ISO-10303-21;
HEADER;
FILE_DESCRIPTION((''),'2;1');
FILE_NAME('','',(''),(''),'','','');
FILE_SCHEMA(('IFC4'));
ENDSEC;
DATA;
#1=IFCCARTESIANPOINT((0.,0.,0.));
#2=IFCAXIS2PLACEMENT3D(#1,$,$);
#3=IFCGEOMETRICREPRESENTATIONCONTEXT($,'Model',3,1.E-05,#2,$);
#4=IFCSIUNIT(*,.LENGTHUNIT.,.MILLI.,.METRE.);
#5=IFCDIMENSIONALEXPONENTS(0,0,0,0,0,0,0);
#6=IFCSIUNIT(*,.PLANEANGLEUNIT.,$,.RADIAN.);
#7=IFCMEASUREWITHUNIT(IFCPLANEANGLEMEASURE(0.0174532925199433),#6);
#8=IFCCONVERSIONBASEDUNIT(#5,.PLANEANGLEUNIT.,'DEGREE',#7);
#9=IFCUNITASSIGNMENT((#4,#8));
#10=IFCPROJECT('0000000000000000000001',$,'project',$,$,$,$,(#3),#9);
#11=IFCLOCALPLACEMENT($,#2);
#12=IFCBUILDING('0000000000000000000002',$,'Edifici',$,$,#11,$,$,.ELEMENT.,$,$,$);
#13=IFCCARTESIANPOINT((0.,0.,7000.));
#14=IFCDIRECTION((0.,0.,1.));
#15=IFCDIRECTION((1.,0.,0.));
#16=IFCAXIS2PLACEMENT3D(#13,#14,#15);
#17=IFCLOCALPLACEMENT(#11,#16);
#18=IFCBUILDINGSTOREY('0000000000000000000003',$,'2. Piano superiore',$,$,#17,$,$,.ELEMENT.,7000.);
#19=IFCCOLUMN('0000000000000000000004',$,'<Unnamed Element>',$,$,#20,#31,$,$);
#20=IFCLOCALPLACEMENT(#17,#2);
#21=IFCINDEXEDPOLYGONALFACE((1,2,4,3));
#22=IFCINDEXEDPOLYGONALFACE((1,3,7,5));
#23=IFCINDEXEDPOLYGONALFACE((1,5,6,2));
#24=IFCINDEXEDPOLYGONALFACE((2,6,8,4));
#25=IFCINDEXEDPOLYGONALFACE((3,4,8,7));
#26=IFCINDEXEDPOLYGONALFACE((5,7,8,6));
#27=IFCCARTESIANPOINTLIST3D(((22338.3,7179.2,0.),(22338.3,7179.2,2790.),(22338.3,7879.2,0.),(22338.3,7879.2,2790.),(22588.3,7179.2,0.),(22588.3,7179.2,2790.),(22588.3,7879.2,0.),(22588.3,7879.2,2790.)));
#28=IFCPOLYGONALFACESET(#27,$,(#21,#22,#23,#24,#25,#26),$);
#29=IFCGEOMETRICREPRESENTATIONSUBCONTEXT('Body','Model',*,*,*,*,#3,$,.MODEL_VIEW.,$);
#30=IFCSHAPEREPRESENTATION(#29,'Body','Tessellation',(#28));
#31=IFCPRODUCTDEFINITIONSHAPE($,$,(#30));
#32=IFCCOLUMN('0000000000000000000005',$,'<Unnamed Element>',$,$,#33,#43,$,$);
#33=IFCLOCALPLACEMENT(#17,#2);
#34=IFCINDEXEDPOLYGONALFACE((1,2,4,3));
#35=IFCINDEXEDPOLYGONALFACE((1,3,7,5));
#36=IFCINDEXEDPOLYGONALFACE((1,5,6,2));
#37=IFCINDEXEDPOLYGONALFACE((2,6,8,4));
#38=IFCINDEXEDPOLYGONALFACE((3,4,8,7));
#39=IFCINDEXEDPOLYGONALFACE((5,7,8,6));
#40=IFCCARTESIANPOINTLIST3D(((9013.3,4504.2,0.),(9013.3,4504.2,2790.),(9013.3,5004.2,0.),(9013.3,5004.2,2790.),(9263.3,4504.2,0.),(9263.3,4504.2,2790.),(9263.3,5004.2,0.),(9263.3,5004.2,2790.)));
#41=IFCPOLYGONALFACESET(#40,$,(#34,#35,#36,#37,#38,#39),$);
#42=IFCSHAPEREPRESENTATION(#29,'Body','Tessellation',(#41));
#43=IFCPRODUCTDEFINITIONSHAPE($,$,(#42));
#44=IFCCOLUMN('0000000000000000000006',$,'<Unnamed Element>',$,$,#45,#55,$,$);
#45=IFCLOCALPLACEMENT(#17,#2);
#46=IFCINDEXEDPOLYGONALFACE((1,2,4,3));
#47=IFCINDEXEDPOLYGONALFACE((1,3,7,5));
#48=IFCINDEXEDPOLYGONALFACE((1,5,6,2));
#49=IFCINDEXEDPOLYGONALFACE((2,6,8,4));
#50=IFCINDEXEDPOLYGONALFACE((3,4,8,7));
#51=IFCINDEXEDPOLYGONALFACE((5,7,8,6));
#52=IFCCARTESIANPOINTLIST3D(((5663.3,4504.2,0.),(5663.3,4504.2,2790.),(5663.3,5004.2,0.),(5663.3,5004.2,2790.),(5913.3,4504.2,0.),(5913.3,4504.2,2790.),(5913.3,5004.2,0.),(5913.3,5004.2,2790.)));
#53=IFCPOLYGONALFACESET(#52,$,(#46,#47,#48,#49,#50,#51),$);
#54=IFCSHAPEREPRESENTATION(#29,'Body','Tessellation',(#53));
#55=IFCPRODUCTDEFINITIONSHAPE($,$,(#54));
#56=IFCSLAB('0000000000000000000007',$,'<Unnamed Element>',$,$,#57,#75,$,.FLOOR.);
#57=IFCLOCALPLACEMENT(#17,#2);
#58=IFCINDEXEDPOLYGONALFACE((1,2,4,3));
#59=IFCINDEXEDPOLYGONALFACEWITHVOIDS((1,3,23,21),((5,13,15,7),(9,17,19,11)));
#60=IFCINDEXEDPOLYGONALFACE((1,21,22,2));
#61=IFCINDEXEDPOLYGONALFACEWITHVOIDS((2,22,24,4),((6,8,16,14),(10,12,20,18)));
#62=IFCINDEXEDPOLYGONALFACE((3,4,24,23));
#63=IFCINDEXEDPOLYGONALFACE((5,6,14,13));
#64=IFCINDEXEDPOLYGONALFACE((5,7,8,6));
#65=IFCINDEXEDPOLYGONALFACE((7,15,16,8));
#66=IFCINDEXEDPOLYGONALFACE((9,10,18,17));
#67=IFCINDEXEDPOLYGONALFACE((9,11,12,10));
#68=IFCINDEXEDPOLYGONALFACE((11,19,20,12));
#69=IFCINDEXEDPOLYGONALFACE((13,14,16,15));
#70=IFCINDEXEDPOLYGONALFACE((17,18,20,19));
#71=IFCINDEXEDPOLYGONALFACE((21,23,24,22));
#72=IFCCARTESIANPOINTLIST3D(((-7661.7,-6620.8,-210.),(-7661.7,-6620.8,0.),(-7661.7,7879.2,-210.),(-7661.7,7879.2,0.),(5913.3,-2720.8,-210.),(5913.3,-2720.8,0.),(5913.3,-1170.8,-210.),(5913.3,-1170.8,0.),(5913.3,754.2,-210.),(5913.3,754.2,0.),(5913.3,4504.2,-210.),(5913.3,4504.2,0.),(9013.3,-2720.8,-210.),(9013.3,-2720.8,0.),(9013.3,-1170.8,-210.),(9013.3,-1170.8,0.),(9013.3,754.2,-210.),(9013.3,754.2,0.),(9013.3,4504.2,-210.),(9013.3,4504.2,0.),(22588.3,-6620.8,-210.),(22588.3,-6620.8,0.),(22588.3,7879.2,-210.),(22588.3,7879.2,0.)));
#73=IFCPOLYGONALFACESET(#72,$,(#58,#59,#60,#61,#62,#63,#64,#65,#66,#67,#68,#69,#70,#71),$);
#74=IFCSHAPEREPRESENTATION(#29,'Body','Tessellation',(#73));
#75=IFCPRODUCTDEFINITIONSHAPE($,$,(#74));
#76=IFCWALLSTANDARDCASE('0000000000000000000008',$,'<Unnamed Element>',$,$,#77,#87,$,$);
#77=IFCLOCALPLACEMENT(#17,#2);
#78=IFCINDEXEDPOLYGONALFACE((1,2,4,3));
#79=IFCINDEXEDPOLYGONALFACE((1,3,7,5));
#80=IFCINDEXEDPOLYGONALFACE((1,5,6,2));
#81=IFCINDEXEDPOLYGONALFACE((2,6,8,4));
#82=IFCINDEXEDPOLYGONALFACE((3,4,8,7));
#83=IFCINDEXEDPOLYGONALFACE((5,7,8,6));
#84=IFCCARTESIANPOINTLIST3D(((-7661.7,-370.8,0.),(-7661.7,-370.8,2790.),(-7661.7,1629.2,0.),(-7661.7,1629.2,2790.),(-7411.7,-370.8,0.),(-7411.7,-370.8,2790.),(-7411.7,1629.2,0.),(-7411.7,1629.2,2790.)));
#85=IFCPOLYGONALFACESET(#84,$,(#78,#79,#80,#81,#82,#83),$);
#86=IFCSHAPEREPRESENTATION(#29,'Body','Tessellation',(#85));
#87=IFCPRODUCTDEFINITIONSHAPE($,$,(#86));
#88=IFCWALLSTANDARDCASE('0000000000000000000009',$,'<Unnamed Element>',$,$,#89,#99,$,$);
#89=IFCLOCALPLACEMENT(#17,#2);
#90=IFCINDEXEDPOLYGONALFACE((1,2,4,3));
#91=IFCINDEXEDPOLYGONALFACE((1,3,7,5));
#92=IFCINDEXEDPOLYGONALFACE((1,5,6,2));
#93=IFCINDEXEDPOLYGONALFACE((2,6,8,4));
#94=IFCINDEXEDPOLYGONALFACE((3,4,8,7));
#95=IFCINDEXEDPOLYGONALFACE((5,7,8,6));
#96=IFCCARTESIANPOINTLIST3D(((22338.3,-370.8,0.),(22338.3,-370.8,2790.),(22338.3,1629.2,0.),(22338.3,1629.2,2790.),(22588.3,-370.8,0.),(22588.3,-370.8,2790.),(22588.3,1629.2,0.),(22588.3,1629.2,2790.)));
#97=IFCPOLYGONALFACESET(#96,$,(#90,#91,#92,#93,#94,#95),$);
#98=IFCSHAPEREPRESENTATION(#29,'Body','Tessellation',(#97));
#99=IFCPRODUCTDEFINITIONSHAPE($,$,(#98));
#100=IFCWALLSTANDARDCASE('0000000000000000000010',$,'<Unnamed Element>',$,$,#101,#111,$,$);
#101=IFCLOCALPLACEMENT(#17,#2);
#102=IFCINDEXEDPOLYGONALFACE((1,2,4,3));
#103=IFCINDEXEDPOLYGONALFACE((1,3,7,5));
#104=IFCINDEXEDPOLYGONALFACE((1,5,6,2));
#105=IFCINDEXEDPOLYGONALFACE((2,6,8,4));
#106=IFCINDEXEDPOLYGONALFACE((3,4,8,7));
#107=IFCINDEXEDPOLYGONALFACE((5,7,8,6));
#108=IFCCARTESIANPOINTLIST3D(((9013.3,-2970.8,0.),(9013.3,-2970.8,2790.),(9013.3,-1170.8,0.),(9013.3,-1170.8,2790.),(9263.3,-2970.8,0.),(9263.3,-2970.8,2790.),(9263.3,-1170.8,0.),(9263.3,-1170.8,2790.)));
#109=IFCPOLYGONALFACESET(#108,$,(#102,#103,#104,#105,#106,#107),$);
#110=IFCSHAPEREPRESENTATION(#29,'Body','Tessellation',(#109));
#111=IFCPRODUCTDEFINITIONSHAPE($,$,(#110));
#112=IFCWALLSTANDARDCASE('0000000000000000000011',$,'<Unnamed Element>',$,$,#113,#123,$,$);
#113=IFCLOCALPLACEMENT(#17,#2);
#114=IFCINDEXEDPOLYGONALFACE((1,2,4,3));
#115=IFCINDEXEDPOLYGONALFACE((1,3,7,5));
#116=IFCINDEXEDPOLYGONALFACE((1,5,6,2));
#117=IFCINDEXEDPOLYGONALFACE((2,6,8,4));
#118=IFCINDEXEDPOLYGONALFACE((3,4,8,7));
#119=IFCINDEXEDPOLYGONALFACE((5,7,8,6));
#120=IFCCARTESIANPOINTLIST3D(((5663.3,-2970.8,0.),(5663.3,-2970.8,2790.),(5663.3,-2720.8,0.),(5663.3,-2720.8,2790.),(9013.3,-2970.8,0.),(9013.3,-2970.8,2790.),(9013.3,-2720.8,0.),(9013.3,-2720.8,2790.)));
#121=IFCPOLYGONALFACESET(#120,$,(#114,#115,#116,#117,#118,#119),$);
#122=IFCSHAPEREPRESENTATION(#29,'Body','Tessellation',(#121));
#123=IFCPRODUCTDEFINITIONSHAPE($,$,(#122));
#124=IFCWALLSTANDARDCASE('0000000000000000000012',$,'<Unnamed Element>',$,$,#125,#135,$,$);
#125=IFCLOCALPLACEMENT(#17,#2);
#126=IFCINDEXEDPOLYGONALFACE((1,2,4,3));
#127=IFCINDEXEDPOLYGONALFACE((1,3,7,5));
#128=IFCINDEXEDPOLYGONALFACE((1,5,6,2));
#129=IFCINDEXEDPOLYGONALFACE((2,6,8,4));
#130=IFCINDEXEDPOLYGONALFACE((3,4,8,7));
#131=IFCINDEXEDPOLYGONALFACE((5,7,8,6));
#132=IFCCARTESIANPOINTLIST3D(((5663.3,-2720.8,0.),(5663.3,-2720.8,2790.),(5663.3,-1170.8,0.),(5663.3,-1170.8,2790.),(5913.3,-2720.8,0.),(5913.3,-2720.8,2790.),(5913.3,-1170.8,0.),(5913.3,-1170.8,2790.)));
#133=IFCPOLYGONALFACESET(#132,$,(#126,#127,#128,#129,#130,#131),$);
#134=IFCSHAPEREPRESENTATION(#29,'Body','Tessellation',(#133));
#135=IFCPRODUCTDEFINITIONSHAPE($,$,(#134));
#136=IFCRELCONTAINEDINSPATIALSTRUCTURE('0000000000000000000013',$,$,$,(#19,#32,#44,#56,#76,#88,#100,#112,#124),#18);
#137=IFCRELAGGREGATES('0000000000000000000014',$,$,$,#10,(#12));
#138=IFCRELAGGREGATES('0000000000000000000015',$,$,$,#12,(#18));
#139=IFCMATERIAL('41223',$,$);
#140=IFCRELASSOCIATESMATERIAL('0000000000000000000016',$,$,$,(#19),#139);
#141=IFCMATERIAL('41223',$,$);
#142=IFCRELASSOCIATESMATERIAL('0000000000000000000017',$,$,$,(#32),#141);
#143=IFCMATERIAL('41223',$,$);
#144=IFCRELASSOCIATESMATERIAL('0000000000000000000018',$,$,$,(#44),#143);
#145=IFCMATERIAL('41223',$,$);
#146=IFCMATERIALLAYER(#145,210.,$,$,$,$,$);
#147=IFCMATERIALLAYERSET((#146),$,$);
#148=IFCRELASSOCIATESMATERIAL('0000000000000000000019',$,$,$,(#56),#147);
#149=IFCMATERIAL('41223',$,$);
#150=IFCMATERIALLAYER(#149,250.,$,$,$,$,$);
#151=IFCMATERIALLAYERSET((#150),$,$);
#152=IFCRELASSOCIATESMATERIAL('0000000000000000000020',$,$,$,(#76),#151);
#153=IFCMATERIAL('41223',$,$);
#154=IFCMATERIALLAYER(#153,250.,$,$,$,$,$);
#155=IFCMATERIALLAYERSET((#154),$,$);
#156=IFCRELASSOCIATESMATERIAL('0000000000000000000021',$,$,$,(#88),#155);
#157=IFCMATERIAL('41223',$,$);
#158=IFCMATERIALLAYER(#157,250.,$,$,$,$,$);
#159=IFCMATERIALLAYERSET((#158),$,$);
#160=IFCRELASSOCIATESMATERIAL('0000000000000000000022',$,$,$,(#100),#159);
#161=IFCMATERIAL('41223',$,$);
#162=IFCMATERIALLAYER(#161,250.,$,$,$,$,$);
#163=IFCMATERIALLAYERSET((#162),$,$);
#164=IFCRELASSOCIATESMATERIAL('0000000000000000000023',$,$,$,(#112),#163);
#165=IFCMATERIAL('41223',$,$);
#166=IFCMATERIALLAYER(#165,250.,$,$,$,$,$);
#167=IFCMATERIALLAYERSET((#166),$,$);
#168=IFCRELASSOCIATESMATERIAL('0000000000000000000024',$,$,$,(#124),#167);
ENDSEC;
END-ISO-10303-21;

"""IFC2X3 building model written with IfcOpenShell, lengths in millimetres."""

from ifc_helpers import new_model, entity, si_unit, converted_unit, frame, frame_2d, origin, origin_with_axes, place, context, subcontext, project, spatial, polyline, rectangle, outline, extrude, material, layer, layer_set, layer_usage, element, save


model = new_model("IFC2X3")

# Units and contexts
model_context = context("Model", 3, precision=1e-05, world=origin())
body_context = subcontext(model_context, "Body", "Model", "MODEL_VIEW")
ifc_project = project(units=[si_unit("LENGTHUNIT", "METRE", prefix="MILLI"), converted_unit("PLANEANGLEUNIT", "DEGREE", entity("IfcPlaneAngleMeasure", 0.0174532925199433), si_unit("PLANEANGLEUNIT", "RADIAN"), dimensions=[0, 0, 0, 0, 0, 0, 0])], contexts=[model_context])

# Building, storey
building_placement = place(None, origin())
building = spatial("IfcBuilding", under=ifc_project, at=building_placement, Name="Edifici", CompositionType="ELEMENT")
storey_placement = place(building_placement, frame((0.0, 0.0, 7000.0), z_axis=(0.0, 0.0, 1.0), x_axis=(1.0, 0.0, 0.0)))
storey = spatial("IfcBuildingStorey", under=building, at=storey_placement, Name="2. Piano superiore", CompositionType="ELEMENT", Elevation=7000.0)

# Columns
ifc_material_1 = material(Name="41223")
column_1_placement = place(storey_placement, frame((22588.3, 7879.2, 0.0), z_axis=(0.0, 0.0, 1.0), x_axis=(1.0, 0.0, 0.0)))
element("IfcColumn", 1, at=column_1_placement, inside=storey, material=ifc_material_1, Name="<Unnamed Element>", context=body_context, shape_type="SweptSolid", body=[
    extrude(rectangle(XDim=250.0, YDim=700.0, at=frame_2d((-125.0, -350.0), x_axis=(-1.0, 0.0))), origin_with_axes(), (0.0, 0.0, 1.0), 2790.0),
])
ifc_material_2 = material(Name="41223")
column_2_placement = place(storey_placement, frame((9263.3, 5004.2, 0.0), z_axis=(0.0, 0.0, 1.0), x_axis=(1.0, 0.0, 0.0)))
element("IfcColumn", 2, at=column_2_placement, inside=storey, material=ifc_material_2, Name="<Unnamed Element>", context=body_context, shape_type="SweptSolid", body=[
    extrude(rectangle(XDim=250.0, YDim=500.0, at=frame_2d((-125.0, -250.0), x_axis=(-1.0, 0.0))), origin_with_axes(), (0.0, 0.0, 1.0), 2790.0),
])
ifc_material_3 = material(Name="41223")
column_3_placement = place(storey_placement, frame((5913.3, 5004.2, 0.0), z_axis=(0.0, 0.0, 1.0), x_axis=(1.0, 0.0, 0.0)))
element("IfcColumn", 3, at=column_3_placement, inside=storey, material=ifc_material_3, Name="<Unnamed Element>", context=body_context, shape_type="SweptSolid", body=[
    extrude(rectangle(XDim=250.0, YDim=500.0, at=frame_2d((-125.0, -250.0), x_axis=(-1.0, 0.0))), origin_with_axes(), (0.0, 0.0, 1.0), 2790.0),
])

# Slab
ifc_material_4 = material(Name="41223")
ifc_layer_1 = layer(ifc_material_4, 210.0)
ifc_layer_set_1 = layer_set([ifc_layer_1])
ifc_layer_usage_1 = layer_usage(ifc_layer_set_1, "AXIS3", "POSITIVE", 0.0)
slab_placement = place(storey_placement, frame((-7661.7, -6620.8, -210.0), z_axis=(0.0, 0.0, 1.0), x_axis=(1.0, 0.0, 0.0)))
element("IfcSlab", 4, at=slab_placement, inside=storey, material=ifc_layer_usage_1, Name="<Unnamed Element>", PredefinedType="FLOOR", context=body_context, shape_type="SweptSolid", body=[
    extrude(outline(polyline([(0.0, 0.0), (30250.0, 0.0), (30250.0, 14500.0), (0.0, 14500.0), (0.0, 0.0)]), holes=[polyline([(13575.0, 11125.0), (16675.0, 11125.0), (16675.0, 7375.0), (13575.0, 7375.0), (13575.0, 11125.0)]), polyline([(16675.0, 3900.0), (13575.0, 3900.0), (13575.0, 5450.0), (16675.0, 5450.0), (16675.0, 3900.0)])]), origin_with_axes(), (0.0, 0.0, 1.0), 210.0),
])

# Walls
ifc_material_5 = material(Name="41223")
ifc_layer_2 = layer(ifc_material_5, 250.0)
ifc_layer_set_2 = layer_set([ifc_layer_2])
ifc_layer_usage_2 = layer_usage(ifc_layer_set_2, "AXIS2", "POSITIVE", 0.0)
wall_1_placement = place(storey_placement, frame((-7661.7, 1629.2, 0.0), z_axis=(0.0, 0.0, 1.0), x_axis=(0.0, -1.0, 0.0)))
element("IfcWallStandardCase", 5, at=wall_1_placement, inside=storey, material=ifc_layer_usage_2, Name="<Unnamed Element>", context=body_context, shape_type="SweptSolid", body=[
    extrude(rectangle(XDim=2000.0, YDim=250.0, at=frame_2d((1000.0, 125.0), x_axis=(1.0, 0.0))), origin_with_axes(), (0.0, 0.0, 1.0), 2790.0),
])
ifc_material_6 = material(Name="41223")
ifc_layer_3 = layer(ifc_material_6, 250.0)
ifc_layer_set_3 = layer_set([ifc_layer_3])
ifc_layer_usage_3 = layer_usage(ifc_layer_set_3, "AXIS2", "POSITIVE", 0.0)
wall_2_placement = place(storey_placement, frame((22338.3, 1629.2, 0.0), z_axis=(0.0, 0.0, 1.0), x_axis=(0.0, -1.0, 0.0)))
element("IfcWallStandardCase", 6, at=wall_2_placement, inside=storey, material=ifc_layer_usage_3, Name="<Unnamed Element>", context=body_context, shape_type="SweptSolid", body=[
    extrude(rectangle(XDim=2000.0, YDim=250.0, at=frame_2d((1000.0, 125.0), x_axis=(1.0, 0.0))), origin_with_axes(), (0.0, 0.0, 1.0), 2790.0),
])
ifc_material_7 = material(Name="41223")
ifc_layer_4 = layer(ifc_material_7, 250.0)
ifc_layer_set_4 = layer_set([ifc_layer_4])
ifc_layer_usage_4 = layer_usage(ifc_layer_set_4, "AXIS2", "POSITIVE", 0.0)
wall_3_placement = place(storey_placement, frame((9263.3, -2970.8, 0.0), z_axis=(0.0, 0.0, 1.0), x_axis=(0.0, 1.0, 0.0)))
element("IfcWallStandardCase", 7, at=wall_3_placement, inside=storey, material=ifc_layer_usage_4, Name="<Unnamed Element>", context=body_context, shape_type="SweptSolid", body=[
    extrude(rectangle(XDim=1800.0, YDim=250.0, at=frame_2d((900.0, 125.0), x_axis=(1.0, 0.0))), origin_with_axes(), (0.0, 0.0, 1.0), 2790.0),
])
ifc_material_8 = material(Name="41223")
ifc_layer_5 = layer(ifc_material_8, 250.0)
ifc_layer_set_5 = layer_set([ifc_layer_5])
ifc_layer_usage_5 = layer_usage(ifc_layer_set_5, "AXIS2", "POSITIVE", 0.0)
wall_4_placement = place(storey_placement, frame((5663.3, -2970.8, 0.0), z_axis=(0.0, 0.0, 1.0), x_axis=(1.0, 0.0, 0.0)))
element("IfcWallStandardCase", 8, at=wall_4_placement, inside=storey, material=ifc_layer_usage_5, Name="<Unnamed Element>", context=body_context, shape_type="SweptSolid", body=[
    extrude(rectangle(XDim=3350.0, YDim=250.0, at=frame_2d((1675.0, 125.0), x_axis=(1.0, 0.0))), origin_with_axes(), (0.0, 0.0, 1.0), 2790.0),
])
ifc_material_9 = material(Name="41223")
ifc_layer_6 = layer(ifc_material_9, 250.0)
ifc_layer_set_6 = layer_set([ifc_layer_6])
ifc_layer_usage_6 = layer_usage(ifc_layer_set_6, "AXIS2", "POSITIVE", 0.0)
wall_5_placement = place(storey_placement, frame((5663.3, -1170.8, 0.0), z_axis=(0.0, 0.0, 1.0), x_axis=(0.0, -1.0, 0.0)))
element("IfcWallStandardCase", 9, at=wall_5_placement, inside=storey, material=ifc_layer_usage_6, Name="<Unnamed Element>", context=body_context, shape_type="SweptSolid", body=[
    extrude(rectangle(XDim=1550.0, YDim=250.0, at=frame_2d((775.0, 125.0), x_axis=(1.0, 0.0))), origin_with_axes(), (0.0, 0.0, 1.0), 2790.0),
])

save(model, "model.ifc")
